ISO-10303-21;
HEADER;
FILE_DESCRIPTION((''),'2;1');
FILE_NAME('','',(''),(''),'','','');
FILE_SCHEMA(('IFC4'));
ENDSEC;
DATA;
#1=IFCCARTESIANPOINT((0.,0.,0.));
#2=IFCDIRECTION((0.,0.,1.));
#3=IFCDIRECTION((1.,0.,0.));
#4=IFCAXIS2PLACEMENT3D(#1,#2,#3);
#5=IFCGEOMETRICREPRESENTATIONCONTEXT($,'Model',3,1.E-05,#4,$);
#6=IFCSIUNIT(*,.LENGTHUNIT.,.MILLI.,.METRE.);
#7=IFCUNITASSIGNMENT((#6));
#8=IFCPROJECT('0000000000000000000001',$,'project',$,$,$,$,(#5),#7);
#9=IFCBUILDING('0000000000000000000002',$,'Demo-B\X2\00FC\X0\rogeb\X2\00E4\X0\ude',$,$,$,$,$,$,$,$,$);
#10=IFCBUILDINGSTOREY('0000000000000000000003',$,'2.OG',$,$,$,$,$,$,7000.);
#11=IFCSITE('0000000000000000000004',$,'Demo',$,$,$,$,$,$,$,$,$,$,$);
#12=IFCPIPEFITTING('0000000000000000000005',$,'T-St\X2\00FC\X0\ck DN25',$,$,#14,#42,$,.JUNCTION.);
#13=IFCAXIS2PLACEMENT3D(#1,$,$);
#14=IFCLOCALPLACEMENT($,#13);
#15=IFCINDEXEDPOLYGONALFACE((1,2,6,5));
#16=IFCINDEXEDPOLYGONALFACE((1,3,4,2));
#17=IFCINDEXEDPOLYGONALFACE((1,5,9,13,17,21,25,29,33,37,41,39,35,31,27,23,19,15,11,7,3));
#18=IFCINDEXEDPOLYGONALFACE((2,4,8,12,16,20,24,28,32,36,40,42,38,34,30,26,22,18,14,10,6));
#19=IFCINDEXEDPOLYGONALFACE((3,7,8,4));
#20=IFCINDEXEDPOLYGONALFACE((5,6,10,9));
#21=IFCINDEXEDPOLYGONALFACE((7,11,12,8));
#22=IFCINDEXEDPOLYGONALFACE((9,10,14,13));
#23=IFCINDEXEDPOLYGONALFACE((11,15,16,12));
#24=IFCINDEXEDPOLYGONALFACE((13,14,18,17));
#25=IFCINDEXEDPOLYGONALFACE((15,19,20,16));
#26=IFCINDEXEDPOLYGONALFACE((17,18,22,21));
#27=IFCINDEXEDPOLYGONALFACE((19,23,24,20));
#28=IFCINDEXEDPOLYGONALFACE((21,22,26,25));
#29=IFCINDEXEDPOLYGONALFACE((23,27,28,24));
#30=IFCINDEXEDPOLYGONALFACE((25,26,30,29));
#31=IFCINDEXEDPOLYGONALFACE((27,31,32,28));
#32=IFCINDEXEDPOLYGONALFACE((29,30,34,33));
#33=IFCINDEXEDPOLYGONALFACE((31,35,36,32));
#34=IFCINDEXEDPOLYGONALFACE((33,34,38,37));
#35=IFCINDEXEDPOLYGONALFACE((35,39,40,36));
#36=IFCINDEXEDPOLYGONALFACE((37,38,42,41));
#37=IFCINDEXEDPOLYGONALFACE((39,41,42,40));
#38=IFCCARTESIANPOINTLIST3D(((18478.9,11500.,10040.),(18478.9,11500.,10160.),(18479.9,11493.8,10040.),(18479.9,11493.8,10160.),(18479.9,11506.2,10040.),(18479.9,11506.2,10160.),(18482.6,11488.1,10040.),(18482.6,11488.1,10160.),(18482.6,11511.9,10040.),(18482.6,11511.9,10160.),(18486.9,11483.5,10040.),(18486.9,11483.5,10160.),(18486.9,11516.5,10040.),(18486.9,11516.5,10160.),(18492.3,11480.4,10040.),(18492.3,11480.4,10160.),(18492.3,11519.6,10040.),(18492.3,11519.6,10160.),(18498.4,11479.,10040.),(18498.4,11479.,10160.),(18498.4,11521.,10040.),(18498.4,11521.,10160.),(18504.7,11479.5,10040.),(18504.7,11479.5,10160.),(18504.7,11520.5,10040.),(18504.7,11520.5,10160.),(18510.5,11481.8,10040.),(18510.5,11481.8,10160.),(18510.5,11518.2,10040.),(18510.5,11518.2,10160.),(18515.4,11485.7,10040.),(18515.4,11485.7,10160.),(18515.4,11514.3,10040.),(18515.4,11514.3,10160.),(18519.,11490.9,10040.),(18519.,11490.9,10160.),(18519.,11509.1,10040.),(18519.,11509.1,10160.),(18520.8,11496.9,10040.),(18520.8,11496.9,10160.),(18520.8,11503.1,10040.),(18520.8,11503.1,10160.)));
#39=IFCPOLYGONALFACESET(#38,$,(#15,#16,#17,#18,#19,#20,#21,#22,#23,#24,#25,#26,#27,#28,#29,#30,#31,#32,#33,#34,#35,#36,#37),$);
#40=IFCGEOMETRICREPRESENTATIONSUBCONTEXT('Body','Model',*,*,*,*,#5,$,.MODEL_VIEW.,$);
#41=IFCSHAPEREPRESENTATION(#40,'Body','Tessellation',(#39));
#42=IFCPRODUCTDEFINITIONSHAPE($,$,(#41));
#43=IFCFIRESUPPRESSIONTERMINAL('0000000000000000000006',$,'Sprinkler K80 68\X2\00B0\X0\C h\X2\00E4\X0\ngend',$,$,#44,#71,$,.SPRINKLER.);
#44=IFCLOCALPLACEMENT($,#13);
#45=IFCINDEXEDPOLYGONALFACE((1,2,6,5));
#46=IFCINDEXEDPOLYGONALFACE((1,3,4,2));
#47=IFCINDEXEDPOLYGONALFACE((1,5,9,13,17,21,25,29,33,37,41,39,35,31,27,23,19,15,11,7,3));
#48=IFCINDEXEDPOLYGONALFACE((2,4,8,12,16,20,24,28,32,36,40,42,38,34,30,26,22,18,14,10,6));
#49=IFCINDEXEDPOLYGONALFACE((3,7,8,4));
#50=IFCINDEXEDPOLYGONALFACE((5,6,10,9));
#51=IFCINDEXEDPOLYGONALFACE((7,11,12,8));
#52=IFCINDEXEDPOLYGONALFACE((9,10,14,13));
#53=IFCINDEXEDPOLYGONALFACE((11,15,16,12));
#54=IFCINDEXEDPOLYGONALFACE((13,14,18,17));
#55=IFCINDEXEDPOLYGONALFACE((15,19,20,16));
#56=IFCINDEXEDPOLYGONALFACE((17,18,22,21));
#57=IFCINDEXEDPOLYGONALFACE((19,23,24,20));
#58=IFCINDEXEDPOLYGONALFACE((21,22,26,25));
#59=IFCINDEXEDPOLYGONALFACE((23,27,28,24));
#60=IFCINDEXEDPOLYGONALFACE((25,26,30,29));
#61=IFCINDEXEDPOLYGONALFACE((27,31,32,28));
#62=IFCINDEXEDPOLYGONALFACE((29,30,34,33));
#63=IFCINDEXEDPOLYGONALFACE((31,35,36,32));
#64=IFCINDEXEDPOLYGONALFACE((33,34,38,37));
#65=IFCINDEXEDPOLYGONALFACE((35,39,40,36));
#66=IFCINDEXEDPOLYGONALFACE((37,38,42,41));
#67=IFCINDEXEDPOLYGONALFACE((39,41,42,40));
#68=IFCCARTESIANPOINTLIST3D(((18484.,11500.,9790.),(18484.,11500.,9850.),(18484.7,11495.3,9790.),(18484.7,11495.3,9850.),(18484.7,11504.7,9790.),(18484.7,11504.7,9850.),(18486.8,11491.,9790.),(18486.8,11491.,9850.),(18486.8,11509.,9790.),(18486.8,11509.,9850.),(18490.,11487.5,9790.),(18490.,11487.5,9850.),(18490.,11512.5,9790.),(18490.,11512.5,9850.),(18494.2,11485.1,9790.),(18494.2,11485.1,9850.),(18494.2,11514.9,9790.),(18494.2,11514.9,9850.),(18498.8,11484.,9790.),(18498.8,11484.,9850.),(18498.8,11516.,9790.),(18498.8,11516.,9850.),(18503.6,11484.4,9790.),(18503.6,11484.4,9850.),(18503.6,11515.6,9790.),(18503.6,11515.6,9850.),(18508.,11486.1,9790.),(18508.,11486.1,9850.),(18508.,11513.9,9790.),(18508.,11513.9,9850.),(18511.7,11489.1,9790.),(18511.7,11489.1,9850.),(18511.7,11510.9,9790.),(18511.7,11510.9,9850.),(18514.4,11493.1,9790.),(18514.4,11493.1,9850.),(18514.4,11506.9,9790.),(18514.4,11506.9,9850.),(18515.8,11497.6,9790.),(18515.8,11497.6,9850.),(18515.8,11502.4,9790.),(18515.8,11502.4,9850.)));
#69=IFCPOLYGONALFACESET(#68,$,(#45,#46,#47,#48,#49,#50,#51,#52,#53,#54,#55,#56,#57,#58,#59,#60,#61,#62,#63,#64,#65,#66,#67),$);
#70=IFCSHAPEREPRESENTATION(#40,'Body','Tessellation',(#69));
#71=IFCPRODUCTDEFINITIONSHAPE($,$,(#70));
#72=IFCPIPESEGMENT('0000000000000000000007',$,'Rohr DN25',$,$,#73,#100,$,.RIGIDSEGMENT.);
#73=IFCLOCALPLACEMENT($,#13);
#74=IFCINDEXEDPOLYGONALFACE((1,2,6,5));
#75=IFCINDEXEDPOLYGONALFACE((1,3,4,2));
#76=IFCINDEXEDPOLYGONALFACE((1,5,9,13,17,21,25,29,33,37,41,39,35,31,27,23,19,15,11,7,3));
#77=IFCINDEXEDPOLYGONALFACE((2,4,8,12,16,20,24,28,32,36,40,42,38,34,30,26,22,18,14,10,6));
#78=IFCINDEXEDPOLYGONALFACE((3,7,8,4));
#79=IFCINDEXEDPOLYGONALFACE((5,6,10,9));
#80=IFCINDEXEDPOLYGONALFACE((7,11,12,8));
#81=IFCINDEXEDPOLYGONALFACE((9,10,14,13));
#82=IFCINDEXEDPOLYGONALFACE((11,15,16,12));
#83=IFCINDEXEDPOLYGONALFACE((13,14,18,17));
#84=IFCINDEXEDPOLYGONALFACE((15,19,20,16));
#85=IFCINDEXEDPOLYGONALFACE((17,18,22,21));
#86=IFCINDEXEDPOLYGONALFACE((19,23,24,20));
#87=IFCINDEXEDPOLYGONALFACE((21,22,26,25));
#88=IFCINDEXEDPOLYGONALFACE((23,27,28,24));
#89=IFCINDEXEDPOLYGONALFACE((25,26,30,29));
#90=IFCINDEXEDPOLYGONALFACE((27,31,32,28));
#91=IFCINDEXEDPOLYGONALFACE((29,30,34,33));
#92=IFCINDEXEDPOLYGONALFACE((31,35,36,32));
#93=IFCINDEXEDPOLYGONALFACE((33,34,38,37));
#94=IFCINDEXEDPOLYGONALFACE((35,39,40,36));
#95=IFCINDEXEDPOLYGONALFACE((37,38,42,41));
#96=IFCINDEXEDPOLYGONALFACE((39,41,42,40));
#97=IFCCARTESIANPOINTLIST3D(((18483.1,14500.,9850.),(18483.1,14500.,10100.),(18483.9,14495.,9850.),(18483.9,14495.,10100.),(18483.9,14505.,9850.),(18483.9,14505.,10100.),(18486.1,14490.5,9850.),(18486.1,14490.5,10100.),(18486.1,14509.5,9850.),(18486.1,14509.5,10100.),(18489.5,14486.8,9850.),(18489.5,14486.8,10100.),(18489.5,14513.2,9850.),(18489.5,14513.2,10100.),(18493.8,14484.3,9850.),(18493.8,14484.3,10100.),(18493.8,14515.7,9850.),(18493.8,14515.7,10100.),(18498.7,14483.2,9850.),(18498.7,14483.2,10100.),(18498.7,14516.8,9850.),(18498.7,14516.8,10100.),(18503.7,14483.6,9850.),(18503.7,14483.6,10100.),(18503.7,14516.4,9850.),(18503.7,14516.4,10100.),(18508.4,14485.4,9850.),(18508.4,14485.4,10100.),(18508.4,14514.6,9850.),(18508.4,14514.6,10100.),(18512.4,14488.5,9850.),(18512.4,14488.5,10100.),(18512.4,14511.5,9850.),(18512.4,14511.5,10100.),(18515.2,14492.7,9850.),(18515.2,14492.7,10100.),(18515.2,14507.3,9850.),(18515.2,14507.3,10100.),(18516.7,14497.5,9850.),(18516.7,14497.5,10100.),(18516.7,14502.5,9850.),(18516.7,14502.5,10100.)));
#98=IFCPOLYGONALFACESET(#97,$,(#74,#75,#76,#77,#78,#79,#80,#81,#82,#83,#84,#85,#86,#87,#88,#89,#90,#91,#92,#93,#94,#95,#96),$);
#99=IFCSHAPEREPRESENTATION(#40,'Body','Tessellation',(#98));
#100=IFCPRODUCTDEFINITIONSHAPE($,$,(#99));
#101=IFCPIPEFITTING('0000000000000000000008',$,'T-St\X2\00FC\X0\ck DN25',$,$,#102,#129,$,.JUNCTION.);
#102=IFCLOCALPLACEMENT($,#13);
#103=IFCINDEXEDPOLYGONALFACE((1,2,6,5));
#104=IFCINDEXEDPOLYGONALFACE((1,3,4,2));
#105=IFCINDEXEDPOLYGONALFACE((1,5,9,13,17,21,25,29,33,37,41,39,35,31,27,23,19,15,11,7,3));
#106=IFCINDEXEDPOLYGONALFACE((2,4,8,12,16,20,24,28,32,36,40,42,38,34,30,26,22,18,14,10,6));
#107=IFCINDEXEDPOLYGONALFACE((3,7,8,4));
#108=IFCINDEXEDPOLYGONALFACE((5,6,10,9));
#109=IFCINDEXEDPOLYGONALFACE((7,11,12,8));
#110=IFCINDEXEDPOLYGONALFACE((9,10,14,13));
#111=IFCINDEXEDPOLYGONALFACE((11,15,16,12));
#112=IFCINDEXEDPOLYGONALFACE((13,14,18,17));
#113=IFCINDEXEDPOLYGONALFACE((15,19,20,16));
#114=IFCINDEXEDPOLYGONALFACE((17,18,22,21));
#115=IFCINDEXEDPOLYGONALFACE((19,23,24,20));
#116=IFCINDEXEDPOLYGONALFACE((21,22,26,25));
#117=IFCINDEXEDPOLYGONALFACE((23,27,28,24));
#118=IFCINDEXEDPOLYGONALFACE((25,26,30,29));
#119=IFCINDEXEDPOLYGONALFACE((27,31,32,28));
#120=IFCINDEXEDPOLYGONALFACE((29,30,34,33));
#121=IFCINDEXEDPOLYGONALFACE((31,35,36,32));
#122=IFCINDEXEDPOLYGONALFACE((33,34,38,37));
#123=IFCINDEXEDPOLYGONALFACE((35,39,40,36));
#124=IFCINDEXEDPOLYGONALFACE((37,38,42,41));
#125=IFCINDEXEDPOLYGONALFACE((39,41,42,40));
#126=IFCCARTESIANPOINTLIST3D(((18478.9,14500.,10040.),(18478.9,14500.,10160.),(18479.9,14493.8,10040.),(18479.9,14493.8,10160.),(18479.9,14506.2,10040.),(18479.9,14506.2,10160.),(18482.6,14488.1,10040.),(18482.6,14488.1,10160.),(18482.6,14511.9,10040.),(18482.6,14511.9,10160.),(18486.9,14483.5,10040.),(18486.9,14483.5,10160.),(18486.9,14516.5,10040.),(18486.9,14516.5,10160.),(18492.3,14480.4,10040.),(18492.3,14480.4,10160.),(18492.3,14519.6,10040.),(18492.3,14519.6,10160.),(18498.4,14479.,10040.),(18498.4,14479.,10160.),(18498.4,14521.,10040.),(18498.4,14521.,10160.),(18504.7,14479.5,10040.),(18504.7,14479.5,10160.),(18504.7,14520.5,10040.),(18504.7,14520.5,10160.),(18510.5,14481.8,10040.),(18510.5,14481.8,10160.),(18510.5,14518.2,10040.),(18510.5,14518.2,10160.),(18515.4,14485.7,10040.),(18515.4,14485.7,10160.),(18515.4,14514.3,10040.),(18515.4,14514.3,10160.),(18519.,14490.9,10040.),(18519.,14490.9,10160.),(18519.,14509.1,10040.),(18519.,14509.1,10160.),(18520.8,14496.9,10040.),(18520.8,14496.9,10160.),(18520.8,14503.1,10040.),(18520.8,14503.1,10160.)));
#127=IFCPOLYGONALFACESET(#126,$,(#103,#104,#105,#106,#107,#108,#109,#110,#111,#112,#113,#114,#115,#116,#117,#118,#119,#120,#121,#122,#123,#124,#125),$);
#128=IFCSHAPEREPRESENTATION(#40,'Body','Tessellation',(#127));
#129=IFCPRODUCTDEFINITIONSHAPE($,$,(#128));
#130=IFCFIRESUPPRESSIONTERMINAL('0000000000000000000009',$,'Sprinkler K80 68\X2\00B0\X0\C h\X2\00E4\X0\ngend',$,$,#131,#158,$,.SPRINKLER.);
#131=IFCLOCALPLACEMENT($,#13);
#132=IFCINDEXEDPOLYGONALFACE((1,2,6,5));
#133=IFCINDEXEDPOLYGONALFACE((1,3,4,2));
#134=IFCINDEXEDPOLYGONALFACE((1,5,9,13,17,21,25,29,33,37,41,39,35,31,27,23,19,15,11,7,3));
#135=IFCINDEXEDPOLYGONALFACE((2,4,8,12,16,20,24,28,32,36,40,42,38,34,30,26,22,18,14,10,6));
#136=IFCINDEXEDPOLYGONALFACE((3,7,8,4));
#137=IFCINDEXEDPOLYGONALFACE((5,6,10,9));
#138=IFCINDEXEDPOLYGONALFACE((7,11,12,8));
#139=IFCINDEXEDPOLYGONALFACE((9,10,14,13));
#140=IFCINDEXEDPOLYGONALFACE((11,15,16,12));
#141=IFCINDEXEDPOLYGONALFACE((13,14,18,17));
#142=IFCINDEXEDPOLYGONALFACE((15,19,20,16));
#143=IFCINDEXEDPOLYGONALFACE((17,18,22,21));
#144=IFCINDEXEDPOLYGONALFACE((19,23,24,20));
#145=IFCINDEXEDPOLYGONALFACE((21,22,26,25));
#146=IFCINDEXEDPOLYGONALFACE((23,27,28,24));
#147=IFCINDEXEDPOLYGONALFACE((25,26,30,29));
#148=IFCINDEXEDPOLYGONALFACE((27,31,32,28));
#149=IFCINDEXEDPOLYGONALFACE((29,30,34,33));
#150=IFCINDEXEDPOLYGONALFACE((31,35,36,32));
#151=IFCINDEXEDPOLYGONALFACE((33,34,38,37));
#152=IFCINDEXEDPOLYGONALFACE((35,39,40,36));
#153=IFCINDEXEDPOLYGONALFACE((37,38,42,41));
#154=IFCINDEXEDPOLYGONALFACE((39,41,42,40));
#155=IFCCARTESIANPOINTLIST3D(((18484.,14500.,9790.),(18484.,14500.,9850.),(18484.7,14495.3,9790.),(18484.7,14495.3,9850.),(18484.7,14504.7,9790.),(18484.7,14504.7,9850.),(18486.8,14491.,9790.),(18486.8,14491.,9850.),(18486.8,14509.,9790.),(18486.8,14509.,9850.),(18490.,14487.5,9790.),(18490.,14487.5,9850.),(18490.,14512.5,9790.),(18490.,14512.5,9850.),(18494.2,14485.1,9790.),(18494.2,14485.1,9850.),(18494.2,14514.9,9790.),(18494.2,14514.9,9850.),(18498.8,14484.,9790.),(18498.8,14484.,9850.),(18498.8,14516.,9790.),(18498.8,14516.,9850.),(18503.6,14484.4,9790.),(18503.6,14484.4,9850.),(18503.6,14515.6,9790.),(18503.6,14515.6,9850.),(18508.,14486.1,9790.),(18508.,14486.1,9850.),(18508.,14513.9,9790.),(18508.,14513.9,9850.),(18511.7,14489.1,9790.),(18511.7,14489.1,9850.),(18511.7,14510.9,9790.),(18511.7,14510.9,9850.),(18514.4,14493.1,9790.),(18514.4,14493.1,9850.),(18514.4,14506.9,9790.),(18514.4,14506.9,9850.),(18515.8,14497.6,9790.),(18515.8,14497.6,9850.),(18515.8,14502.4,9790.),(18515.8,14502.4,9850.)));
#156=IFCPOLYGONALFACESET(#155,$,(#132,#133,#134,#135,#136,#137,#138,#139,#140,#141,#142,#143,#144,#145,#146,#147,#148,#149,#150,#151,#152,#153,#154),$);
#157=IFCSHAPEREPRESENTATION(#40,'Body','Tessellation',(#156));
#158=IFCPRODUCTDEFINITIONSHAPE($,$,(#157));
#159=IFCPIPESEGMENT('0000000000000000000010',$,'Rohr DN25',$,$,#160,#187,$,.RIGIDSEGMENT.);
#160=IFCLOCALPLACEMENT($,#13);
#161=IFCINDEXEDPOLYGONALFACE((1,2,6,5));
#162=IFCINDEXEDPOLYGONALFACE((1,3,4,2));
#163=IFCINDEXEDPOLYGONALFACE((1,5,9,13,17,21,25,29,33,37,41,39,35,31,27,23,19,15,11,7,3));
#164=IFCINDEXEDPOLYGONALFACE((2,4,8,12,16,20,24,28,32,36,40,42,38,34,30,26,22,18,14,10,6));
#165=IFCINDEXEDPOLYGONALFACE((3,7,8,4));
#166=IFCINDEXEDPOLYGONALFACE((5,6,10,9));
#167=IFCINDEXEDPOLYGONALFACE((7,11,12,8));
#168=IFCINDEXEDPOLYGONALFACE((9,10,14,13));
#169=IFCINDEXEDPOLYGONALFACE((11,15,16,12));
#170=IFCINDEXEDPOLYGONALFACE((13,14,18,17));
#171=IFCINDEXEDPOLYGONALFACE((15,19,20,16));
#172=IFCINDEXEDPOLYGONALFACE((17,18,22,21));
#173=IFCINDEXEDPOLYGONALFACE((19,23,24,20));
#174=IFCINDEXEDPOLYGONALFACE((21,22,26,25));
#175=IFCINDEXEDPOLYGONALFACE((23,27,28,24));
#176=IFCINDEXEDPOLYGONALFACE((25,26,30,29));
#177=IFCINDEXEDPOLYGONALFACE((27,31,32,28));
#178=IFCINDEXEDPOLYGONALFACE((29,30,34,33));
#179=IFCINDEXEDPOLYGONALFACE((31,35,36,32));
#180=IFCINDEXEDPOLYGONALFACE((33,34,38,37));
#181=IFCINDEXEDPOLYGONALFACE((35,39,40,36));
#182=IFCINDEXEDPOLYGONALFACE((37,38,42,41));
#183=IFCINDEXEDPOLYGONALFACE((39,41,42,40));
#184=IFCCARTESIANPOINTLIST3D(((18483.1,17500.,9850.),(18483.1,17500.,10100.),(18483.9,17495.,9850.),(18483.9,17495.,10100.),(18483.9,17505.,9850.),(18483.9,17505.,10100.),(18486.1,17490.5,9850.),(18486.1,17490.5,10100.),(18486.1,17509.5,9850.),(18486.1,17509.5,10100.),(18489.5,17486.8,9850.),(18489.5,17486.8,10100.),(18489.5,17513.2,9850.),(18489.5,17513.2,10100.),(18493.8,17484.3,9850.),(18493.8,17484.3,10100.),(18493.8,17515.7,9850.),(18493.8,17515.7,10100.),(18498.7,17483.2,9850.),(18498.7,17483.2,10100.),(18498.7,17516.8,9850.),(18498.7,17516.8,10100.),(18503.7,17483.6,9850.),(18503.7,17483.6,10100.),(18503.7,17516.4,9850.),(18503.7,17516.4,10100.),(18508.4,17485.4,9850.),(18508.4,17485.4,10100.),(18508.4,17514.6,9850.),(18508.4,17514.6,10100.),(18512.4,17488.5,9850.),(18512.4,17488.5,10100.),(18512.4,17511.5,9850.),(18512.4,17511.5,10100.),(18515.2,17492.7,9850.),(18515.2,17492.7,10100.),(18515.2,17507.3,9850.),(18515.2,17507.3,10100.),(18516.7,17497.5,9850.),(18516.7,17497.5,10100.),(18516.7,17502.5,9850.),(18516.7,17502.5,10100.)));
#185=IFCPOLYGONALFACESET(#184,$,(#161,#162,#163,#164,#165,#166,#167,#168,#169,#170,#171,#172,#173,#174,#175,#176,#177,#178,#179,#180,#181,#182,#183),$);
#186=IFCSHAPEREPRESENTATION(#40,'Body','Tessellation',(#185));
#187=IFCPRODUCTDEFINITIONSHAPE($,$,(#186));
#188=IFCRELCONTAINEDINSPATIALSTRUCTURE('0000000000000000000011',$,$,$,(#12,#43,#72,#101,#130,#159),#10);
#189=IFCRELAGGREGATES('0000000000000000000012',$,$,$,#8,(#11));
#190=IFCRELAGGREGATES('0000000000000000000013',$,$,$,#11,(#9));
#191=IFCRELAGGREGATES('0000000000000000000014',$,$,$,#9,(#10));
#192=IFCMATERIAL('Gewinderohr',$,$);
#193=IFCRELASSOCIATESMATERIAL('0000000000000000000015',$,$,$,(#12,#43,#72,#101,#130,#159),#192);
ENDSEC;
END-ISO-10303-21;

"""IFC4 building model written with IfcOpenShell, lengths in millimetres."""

from ifc_helpers import new_model, si_unit, frame, origin_with_axes, place, context, subcontext, project, spatial, circle, extrude, material, element, save


model = new_model("IFC4")

# Units and contexts
model_context = context("Model", 3, precision=1e-05, world=origin_with_axes())
body_context = subcontext(model_context, "Body", "Model", "MODEL_VIEW")
ifc_project = project(units=[si_unit("LENGTHUNIT", "METRE", prefix="MILLI")], contexts=[model_context])

# Site, building, storey
site = spatial("IfcSite", under=ifc_project, Name="Demo")
building = spatial("IfcBuilding", under=site, Name="Demo-Bürogebäude")
storey = spatial("IfcBuildingStorey", under=building, Name="2.OG", Elevation=7000.0)

# Shared definitions
ifc_material_1 = material(Name="Gewinderohr")

# Pipe fitting
pipe_fitting_1_placement = place(None, frame((18500.0, 11500.0, 10160.0), z_axis=(0.0, 0.0, -1.0), x_axis=(-1.0, 0.0, 0.0)))
element("IfcPipeFitting", 1, at=pipe_fitting_1_placement, inside=storey, material=ifc_material_1, Name="T-Stück DN25", PredefinedType="JUNCTION", context=body_context, shape_type="SweptSolid", body=[
    extrude(circle(Radius=21.1), origin_with_axes(), (0.0, 0.0, 1.0), 120.0),
])

# Fire suppression terminal
fire_suppression_terminal_1_placement = place(None, frame((18500.0, 11500.0, 9850.0), z_axis=(0.0, 0.0, -1.0), x_axis=(-1.0, 0.0, 0.0)))
element("IfcFireSuppressionTerminal", 2, at=fire_suppression_terminal_1_placement, inside=storey, material=ifc_material_1, Name="Sprinkler K80 68°C hängend", PredefinedType="SPRINKLER", context=body_context, shape_type="SweptSolid", body=[
    extrude(circle(Radius=16.0), origin_with_axes(), (0.0, 0.0, 1.0), 60.0),
])

# Pipe segment
pipe_segment_1_placement = place(None, frame((18500.0, 14500.0, 10100.0), z_axis=(0.0, 0.0, -1.0), x_axis=(-1.0, 0.0, 0.0)))
element("IfcPipeSegment", 3, at=pipe_segment_1_placement, inside=storey, material=ifc_material_1, Name="Rohr DN25", PredefinedType="RIGIDSEGMENT", context=body_context, shape_type="SweptSolid", body=[
    extrude(circle(Radius=16.9), origin_with_axes(), (0.0, 0.0, 1.0), 250.0),
])

# Pipe fitting
pipe_fitting_2_placement = place(None, frame((18500.0, 14500.0, 10160.0), z_axis=(0.0, 0.0, -1.0), x_axis=(-1.0, 0.0, 0.0)))
element("IfcPipeFitting", 4, at=pipe_fitting_2_placement, inside=storey, material=ifc_material_1, Name="T-Stück DN25", PredefinedType="JUNCTION", context=body_context, shape_type="SweptSolid", body=[
    extrude(circle(Radius=21.1), origin_with_axes(), (0.0, 0.0, 1.0), 120.0),
])

# Fire suppression terminal
fire_suppression_terminal_2_placement = place(None, frame((18500.0, 14500.0, 9850.0), z_axis=(0.0, 0.0, -1.0), x_axis=(-1.0, 0.0, 0.0)))
element("IfcFireSuppressionTerminal", 5, at=fire_suppression_terminal_2_placement, inside=storey, material=ifc_material_1, Name="Sprinkler K80 68°C hängend", PredefinedType="SPRINKLER", context=body_context, shape_type="SweptSolid", body=[
    extrude(circle(Radius=16.0), origin_with_axes(), (0.0, 0.0, 1.0), 60.0),
])

# Pipe segment
pipe_segment_2_placement = place(None, frame((18500.0, 17500.0, 10100.0), z_axis=(0.0, 0.0, -1.0), x_axis=(-1.0, 0.0, 0.0)))
element("IfcPipeSegment", 6, at=pipe_segment_2_placement, inside=storey, material=ifc_material_1, Name="Rohr DN25", PredefinedType="RIGIDSEGMENT", context=body_context, shape_type="SweptSolid", body=[
    extrude(circle(Radius=16.9), origin_with_axes(), (0.0, 0.0, 1.0), 250.0),
])

save(model, "model.ifc")
